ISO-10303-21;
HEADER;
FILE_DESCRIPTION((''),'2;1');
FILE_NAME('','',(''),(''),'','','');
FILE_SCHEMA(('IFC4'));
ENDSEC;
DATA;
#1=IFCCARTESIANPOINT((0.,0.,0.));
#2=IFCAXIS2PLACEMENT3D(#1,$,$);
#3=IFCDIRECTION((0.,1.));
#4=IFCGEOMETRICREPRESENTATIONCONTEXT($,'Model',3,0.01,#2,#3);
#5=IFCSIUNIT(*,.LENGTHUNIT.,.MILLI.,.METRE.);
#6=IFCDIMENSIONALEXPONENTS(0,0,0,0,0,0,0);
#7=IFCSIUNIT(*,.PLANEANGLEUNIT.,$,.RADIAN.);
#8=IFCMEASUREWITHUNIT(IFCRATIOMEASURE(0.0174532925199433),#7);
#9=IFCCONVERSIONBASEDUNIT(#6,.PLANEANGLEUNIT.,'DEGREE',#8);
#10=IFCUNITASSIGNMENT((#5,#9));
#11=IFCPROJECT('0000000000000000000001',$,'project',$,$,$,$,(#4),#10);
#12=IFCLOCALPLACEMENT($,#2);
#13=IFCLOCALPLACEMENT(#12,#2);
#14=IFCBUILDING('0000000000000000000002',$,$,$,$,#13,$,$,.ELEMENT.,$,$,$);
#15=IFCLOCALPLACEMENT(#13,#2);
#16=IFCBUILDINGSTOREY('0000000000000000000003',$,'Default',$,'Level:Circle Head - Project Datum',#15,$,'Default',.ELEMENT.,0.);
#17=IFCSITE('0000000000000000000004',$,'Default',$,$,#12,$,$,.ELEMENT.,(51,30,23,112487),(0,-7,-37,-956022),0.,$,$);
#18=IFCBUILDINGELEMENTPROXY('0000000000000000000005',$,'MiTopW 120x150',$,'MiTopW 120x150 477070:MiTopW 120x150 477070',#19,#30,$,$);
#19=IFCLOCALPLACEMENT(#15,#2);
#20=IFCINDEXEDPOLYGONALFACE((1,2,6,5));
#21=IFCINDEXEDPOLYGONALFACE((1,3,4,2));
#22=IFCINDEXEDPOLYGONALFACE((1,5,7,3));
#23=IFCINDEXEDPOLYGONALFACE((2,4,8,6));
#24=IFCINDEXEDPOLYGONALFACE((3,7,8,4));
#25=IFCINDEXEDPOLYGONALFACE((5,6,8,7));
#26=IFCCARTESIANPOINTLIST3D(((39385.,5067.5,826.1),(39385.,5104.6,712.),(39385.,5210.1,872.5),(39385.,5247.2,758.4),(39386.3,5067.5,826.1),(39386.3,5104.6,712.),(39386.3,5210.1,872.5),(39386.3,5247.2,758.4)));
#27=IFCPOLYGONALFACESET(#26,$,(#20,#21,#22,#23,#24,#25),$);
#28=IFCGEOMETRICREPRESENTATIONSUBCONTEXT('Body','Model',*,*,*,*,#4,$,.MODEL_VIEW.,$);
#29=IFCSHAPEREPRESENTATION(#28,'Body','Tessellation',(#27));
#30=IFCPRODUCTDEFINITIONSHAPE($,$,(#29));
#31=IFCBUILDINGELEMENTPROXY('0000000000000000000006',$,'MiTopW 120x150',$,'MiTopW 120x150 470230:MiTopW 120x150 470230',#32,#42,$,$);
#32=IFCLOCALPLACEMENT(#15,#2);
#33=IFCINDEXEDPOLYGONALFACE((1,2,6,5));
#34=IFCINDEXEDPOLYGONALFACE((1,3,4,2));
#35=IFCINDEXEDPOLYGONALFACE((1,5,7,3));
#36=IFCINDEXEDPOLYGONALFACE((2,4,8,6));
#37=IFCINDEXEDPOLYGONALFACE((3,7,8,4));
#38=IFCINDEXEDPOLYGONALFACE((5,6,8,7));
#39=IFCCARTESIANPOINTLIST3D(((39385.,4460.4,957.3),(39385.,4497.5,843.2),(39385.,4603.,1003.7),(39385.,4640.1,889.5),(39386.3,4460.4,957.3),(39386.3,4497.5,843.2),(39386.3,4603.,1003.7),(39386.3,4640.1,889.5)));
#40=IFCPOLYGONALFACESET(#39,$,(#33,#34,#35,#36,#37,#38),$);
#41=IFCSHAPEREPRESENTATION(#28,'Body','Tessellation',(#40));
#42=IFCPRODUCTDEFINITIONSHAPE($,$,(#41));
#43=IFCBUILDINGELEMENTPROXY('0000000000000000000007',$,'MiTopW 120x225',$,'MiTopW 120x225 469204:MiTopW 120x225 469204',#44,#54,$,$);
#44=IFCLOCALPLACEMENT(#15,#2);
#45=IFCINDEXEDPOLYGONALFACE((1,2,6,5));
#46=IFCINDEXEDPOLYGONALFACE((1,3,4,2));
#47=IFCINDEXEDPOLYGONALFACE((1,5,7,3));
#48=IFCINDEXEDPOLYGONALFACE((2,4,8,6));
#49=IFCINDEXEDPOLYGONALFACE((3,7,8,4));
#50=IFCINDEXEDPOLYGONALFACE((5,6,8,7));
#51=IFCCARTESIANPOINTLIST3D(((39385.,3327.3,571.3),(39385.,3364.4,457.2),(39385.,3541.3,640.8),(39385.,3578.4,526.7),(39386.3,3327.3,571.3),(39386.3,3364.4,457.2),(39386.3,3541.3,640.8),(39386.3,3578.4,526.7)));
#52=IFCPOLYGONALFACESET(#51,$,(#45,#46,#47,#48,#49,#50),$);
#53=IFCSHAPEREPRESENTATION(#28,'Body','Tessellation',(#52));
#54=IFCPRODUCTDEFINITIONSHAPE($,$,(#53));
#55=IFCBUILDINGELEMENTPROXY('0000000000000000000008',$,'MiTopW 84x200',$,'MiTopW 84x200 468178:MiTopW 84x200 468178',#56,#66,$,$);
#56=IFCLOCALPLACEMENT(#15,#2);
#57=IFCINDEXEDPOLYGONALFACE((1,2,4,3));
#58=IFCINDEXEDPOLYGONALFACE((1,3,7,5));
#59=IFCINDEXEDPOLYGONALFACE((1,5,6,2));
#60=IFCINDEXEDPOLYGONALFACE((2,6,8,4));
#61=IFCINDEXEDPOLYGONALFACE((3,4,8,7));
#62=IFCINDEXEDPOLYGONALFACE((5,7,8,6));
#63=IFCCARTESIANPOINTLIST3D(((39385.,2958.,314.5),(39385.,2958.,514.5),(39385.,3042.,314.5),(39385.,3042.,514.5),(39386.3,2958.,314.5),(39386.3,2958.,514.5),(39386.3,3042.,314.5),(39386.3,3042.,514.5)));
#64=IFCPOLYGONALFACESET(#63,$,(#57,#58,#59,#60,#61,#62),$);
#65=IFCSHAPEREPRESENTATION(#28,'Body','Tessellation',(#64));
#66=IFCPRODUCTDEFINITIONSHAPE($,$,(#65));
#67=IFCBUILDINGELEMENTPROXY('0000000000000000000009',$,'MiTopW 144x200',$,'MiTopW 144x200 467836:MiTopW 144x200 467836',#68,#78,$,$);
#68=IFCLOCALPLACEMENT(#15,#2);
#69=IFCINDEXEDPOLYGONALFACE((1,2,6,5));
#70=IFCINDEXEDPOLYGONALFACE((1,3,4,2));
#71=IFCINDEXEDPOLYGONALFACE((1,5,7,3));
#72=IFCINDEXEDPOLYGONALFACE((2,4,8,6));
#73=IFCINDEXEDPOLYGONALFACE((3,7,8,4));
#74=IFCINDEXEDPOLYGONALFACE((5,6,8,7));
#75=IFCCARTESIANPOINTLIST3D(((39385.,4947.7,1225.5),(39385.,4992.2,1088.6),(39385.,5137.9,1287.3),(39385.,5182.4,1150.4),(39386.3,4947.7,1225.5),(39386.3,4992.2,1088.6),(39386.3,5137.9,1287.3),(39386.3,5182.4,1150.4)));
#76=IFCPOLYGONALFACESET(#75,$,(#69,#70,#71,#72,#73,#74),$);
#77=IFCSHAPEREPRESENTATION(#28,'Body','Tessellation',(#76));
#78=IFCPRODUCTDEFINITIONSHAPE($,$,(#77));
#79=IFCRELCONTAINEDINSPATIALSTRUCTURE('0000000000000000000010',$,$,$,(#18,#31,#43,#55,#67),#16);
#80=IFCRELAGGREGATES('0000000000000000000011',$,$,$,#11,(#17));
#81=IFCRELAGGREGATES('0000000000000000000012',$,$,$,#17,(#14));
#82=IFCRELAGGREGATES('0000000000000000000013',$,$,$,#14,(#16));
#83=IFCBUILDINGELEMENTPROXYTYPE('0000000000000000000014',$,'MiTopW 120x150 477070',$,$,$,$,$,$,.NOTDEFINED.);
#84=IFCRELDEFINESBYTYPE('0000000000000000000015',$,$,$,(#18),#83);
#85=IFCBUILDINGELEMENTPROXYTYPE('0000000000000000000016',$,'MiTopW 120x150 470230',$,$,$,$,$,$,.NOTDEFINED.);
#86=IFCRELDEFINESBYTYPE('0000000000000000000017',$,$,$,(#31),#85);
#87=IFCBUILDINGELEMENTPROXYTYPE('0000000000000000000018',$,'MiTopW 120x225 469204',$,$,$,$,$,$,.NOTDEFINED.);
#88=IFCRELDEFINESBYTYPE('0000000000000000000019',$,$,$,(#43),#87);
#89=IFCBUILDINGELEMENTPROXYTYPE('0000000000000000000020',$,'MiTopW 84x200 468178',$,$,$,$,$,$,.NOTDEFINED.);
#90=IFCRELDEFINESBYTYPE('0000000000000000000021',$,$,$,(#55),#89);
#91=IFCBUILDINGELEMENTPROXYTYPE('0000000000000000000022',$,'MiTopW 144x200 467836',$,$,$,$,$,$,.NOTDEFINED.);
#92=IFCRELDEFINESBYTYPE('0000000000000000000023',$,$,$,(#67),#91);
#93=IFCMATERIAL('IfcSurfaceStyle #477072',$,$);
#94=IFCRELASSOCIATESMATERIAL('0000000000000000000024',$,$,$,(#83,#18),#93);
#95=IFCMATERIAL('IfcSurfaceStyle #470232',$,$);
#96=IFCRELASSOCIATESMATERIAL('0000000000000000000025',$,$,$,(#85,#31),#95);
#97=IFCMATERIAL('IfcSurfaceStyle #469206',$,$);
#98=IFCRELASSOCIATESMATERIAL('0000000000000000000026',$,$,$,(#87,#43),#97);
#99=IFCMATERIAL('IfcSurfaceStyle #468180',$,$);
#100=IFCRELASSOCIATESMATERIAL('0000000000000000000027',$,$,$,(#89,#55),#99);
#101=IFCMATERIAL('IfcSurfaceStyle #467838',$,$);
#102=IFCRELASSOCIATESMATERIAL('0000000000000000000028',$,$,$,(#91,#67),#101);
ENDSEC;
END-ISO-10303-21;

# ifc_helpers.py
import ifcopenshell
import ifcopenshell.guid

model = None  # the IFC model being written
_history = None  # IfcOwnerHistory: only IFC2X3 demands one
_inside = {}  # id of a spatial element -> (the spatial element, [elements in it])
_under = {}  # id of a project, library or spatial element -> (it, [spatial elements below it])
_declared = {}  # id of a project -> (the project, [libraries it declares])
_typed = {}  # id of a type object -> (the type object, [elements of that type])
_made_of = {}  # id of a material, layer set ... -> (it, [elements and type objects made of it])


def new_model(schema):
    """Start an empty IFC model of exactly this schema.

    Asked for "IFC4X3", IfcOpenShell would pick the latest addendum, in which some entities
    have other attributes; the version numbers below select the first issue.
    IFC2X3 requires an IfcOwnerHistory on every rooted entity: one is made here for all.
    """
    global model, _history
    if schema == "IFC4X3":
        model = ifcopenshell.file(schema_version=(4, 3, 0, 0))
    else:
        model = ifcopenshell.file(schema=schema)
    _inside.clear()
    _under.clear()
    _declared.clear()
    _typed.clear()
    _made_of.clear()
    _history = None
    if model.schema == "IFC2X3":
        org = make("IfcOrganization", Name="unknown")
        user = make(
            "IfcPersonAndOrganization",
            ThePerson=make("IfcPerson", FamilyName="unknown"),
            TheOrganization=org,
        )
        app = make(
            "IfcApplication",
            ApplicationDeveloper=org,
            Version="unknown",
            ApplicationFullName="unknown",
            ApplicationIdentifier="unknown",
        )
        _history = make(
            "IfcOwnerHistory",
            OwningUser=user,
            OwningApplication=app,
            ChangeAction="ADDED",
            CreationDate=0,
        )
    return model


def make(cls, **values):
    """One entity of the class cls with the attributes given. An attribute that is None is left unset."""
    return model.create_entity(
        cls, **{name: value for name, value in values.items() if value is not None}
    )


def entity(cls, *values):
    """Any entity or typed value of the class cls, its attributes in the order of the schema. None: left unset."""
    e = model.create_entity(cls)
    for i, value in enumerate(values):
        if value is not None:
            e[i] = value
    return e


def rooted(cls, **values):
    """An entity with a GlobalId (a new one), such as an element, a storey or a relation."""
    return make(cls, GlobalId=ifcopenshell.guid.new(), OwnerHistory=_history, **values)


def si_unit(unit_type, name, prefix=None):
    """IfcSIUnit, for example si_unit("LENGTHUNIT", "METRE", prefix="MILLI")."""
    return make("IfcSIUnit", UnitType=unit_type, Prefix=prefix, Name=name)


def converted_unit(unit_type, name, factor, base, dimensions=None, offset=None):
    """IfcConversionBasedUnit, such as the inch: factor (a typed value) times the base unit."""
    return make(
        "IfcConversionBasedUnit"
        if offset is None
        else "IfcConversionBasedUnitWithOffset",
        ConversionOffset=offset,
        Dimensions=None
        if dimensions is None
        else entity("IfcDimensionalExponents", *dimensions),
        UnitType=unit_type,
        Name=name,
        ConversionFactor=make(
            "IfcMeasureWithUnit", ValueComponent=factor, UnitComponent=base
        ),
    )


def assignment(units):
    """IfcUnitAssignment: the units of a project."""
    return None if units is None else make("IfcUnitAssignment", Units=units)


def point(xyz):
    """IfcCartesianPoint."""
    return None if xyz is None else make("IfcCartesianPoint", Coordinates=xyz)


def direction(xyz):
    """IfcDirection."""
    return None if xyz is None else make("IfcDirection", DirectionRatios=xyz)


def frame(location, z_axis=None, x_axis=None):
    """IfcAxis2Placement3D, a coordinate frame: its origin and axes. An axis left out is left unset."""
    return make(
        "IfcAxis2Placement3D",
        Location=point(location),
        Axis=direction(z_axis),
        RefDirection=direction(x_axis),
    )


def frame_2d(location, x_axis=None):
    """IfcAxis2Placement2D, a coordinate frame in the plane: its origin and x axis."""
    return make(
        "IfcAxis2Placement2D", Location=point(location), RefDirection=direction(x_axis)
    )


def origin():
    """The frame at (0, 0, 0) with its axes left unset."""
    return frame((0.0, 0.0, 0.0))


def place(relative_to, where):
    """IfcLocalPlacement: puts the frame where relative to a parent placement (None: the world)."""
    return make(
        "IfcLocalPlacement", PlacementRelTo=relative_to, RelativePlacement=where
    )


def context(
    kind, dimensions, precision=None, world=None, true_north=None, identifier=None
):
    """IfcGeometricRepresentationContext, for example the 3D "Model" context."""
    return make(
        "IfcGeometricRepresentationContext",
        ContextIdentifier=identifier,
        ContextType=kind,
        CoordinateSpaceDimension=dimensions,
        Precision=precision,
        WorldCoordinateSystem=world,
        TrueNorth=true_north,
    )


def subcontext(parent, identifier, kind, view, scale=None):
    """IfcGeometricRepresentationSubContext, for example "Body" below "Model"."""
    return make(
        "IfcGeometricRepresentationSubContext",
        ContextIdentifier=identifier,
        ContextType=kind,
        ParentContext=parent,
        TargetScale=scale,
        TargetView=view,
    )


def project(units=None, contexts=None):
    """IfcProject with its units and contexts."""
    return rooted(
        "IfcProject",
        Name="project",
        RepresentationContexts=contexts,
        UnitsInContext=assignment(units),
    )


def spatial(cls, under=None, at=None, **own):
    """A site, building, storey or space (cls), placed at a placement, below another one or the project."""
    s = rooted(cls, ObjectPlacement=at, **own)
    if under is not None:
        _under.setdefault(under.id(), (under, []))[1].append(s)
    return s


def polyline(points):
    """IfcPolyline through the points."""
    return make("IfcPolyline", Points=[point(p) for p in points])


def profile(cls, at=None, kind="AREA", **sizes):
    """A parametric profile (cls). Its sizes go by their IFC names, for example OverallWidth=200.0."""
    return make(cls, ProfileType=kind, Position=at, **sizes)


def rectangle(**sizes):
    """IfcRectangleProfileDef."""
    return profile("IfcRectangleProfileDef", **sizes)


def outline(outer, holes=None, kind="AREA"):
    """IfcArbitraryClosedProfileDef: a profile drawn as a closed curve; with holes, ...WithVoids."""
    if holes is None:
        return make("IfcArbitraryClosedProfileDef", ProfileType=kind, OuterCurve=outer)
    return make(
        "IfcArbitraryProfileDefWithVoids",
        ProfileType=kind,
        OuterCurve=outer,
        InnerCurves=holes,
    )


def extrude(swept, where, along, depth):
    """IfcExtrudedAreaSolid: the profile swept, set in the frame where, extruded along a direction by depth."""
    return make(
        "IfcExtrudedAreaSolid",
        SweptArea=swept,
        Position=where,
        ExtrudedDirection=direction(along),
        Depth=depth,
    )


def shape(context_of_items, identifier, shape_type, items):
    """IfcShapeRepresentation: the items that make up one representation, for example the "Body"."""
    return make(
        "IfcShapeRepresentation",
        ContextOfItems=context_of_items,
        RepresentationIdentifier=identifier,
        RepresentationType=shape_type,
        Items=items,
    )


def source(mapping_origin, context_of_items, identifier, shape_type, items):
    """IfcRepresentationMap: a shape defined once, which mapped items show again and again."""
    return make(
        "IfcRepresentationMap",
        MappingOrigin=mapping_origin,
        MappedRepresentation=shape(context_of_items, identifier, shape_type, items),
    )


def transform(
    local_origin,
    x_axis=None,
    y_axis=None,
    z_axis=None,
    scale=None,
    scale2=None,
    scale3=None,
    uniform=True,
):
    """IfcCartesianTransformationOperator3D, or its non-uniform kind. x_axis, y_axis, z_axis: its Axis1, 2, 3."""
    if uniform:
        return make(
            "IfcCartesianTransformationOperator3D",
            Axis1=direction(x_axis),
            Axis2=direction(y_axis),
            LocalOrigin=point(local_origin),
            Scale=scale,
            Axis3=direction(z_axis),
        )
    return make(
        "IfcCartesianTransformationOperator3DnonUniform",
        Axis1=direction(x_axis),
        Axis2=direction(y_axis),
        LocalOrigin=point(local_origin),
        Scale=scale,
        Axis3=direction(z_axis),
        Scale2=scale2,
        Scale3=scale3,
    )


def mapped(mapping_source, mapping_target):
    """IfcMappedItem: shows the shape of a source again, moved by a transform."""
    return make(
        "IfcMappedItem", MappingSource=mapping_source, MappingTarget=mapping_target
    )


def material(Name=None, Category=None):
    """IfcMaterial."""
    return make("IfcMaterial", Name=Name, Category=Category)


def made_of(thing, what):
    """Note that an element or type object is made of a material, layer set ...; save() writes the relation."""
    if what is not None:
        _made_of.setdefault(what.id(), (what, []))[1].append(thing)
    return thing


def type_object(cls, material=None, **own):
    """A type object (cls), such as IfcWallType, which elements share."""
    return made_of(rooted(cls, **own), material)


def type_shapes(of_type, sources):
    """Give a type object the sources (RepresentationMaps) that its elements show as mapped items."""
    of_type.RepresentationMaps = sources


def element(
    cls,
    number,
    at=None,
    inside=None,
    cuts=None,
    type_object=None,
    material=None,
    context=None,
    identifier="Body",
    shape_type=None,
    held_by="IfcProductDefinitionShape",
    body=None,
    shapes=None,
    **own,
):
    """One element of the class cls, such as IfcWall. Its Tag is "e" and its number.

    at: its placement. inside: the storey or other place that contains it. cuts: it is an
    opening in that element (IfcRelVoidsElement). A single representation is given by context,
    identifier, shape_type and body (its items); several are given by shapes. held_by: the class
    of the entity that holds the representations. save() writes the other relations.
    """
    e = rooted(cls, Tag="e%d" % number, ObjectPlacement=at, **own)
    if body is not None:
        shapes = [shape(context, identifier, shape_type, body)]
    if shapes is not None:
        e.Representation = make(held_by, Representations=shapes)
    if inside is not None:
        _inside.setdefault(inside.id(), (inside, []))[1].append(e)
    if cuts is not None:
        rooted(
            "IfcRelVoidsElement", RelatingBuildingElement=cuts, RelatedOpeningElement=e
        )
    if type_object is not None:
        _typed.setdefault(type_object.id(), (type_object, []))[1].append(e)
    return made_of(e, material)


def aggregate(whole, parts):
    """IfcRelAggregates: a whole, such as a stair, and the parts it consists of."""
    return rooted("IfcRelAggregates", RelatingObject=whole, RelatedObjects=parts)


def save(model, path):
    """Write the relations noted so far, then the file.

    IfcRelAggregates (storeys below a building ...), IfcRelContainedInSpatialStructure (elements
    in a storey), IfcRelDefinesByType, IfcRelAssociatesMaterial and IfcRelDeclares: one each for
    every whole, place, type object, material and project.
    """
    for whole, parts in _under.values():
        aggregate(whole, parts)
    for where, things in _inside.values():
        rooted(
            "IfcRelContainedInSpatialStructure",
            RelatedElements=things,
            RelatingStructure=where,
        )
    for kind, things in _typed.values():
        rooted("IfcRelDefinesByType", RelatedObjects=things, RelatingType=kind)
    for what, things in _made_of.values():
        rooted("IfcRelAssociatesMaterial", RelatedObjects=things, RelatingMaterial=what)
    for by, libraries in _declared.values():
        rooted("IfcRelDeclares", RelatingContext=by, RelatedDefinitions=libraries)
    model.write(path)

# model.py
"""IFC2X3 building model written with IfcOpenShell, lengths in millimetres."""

from ifc_helpers import new_model, entity, si_unit, converted_unit, direction, frame, frame_2d, origin, place, context, subcontext, project, spatial, polyline, rectangle, outline, extrude, source, transform, mapped, material, type_object, type_shapes, element, save


model = new_model("IFC2X3")

# Units and contexts
model_context = context("Model", 3, precision=0.01, world=origin(), true_north=direction((0.0, 1.0)))
body_context = subcontext(model_context, "Body", "Model", "MODEL_VIEW")
ifc_project = project(units=[si_unit("LENGTHUNIT", "METRE", prefix="MILLI"), converted_unit("PLANEANGLEUNIT", "DEGREE", entity("IfcRatioMeasure", 0.0174532925199433), si_unit("PLANEANGLEUNIT", "RADIAN"), dimensions=[0, 0, 0, 0, 0, 0, 0])], contexts=[model_context])

# Site, building, storey
site_placement = place(None, origin())
site = spatial("IfcSite", under=ifc_project, at=site_placement, Name="Default", CompositionType="ELEMENT", RefLatitude=(51, 30, 23, 112487), RefLongitude=(0, -7, -37, -956022), RefElevation=0.0)
building_placement = place(site_placement, origin())
building = spatial("IfcBuilding", under=site, at=building_placement, CompositionType="ELEMENT")
storey_placement = place(building_placement, origin())
storey = spatial("IfcBuildingStorey", under=building, at=storey_placement, Name="Default", ObjectType="Level:Circle Head - Project Datum", LongName="Default", CompositionType="ELEMENT", Elevation=0.0)

# Building element proxies
ifc_material_1 = material(Name="IfcSurfaceStyle #477072")
building_element_proxy_type_1 = type_object("IfcBuildingElementProxyType", Name="MiTopW 120x150 477070", PredefinedType="NOTDEFINED", material=ifc_material_1)
shared_shape_1 = source(origin(), body_context, "Body", "SweptSolid", [
    extrude(outline(polyline([(-75.0, -60.0), (75.0, -60.0), (75.0, 60.0), (-75.0, 60.0), (-75.0, -60.0)])), frame((75.0, 60.0, 0.0), z_axis=(0.0, 0.0, 1.0), x_axis=(-1.0, 0.0, 0.0)), (0.0, 0.0, 1.0), 1.3),
])
type_shapes(building_element_proxy_type_1, [shared_shape_1])
proxy_1_placement = place(building_placement, frame((39386.3, 5067.5, 826.1), z_axis=(-1.0, 0.0, 0.0), x_axis=(0.0, 0.951057, 0.309017)))
element("IfcBuildingElementProxy", 1, at=proxy_1_placement, inside=storey, type_object=building_element_proxy_type_1, material=ifc_material_1, Name="MiTopW 120x150", ObjectType="MiTopW 120x150 477070:MiTopW 120x150 477070", context=body_context, shape_type="MappedRepresentation", body=[
    mapped(shared_shape_1, transform((0.0, 0.0, 0.0), scale=1.0)),
])
ifc_material_2 = material(Name="IfcSurfaceStyle #470232")
building_element_proxy_type_2 = type_object("IfcBuildingElementProxyType", Name="MiTopW 120x150 470230", PredefinedType="NOTDEFINED", material=ifc_material_2)
shared_shape_2 = source(origin(), body_context, "Body", "SweptSolid", [
    extrude(outline(polyline([(-75.0, -60.0), (75.0, -60.0), (75.0, 60.0), (-75.0, 60.0), (-75.0, -60.0)])), frame((75.0, 60.0, 0.0), z_axis=(0.0, 0.0, 1.0), x_axis=(-1.0, 0.0, 0.0)), (0.0, 0.0, 1.0), 1.3),
])
type_shapes(building_element_proxy_type_2, [shared_shape_2])
proxy_2_placement = place(building_placement, frame((39386.3, 4460.4, 957.3), z_axis=(-1.0, 0.0, 0.0), x_axis=(0.0, 0.951057, 0.309017)))
element("IfcBuildingElementProxy", 2, at=proxy_2_placement, inside=storey, type_object=building_element_proxy_type_2, material=ifc_material_2, Name="MiTopW 120x150", ObjectType="MiTopW 120x150 470230:MiTopW 120x150 470230", context=body_context, shape_type="MappedRepresentation", body=[
    mapped(shared_shape_2, transform((0.0, 0.0, 0.0), scale=1.0)),
])
ifc_material_3 = material(Name="IfcSurfaceStyle #469206")
building_element_proxy_type_3 = type_object("IfcBuildingElementProxyType", Name="MiTopW 120x225 469204", PredefinedType="NOTDEFINED", material=ifc_material_3)
shared_shape_3 = source(origin(), body_context, "Body", "SweptSolid", [
    extrude(outline(polyline([(-112.5, -60.0), (112.5, -60.0), (112.5, 60.0), (-112.5, 60.0), (-112.5, -60.0)])), frame((112.5, 60.0, 0.0), z_axis=(0.0, 0.0, 1.0), x_axis=(-1.0, 0.0, 0.0)), (0.0, 0.0, 1.0), 1.3),
])
type_shapes(building_element_proxy_type_3, [shared_shape_3])
proxy_3_placement = place(building_placement, frame((39386.3, 3327.3, 571.3), z_axis=(-1.0, 0.0, 0.0), x_axis=(0.0, 0.951057, 0.309017)))
element("IfcBuildingElementProxy", 3, at=proxy_3_placement, inside=storey, type_object=building_element_proxy_type_3, material=ifc_material_3, Name="MiTopW 120x225", ObjectType="MiTopW 120x225 469204:MiTopW 120x225 469204", context=body_context, shape_type="MappedRepresentation", body=[
    mapped(shared_shape_3, transform((0.0, 0.0, 0.0), scale=1.0)),
])
ifc_material_4 = material(Name="IfcSurfaceStyle #468180")
building_element_proxy_type_4 = type_object("IfcBuildingElementProxyType", Name="MiTopW 84x200 468178", PredefinedType="NOTDEFINED", material=ifc_material_4)
shared_shape_4 = source(origin(), body_context, "Body", "SweptSolid", [
    extrude(rectangle(XDim=200.0, YDim=84.0, at=frame_2d((0.0, 0.0), x_axis=(1.0, 0.0))), frame((100.0, 42.0, 0.0), z_axis=(0.0, 0.0, 1.0), x_axis=(-1.0, 0.0, 0.0)), (0.0, 0.0, 1.0), 1.3),
])
type_shapes(building_element_proxy_type_4, [shared_shape_4])
proxy_4_placement = place(building_placement, frame((39386.3, 3042.0, 514.5), z_axis=(-1.0, 0.0, 0.0), x_axis=(0.0, 0.0, -1.0)))
element("IfcBuildingElementProxy", 4, at=proxy_4_placement, inside=storey, type_object=building_element_proxy_type_4, material=ifc_material_4, Name="MiTopW 84x200", ObjectType="MiTopW 84x200 468178:MiTopW 84x200 468178", context=body_context, shape_type="MappedRepresentation", body=[
    mapped(shared_shape_4, transform((0.0, 0.0, 0.0), scale=1.0)),
])
ifc_material_5 = material(Name="IfcSurfaceStyle #467838")
building_element_proxy_type_5 = type_object("IfcBuildingElementProxyType", Name="MiTopW 144x200 467836", PredefinedType="NOTDEFINED", material=ifc_material_5)
shared_shape_5 = source(origin(), body_context, "Body", "SweptSolid", [
    extrude(outline(polyline([(-100.0, -72.0), (100.0, -72.0), (100.0, 72.0), (-100.0, 72.0), (-100.0, -72.0)])), frame((100.0, 72.0, 0.0), z_axis=(0.0, 0.0, 1.0), x_axis=(-1.0, 0.0, 0.0)), (0.0, 0.0, 1.0), 1.3),
])
type_shapes(building_element_proxy_type_5, [shared_shape_5])
proxy_5_placement = place(building_placement, frame((39386.3, 4947.7, 1225.5), z_axis=(-1.0, 0.0, 0.0), x_axis=(0.0, 0.951057, 0.309017)))
element("IfcBuildingElementProxy", 5, at=proxy_5_placement, inside=storey, type_object=building_element_proxy_type_5, material=ifc_material_5, Name="MiTopW 144x200", ObjectType="MiTopW 144x200 467836:MiTopW 144x200 467836", context=body_context, shape_type="MappedRepresentation", body=[
    mapped(shared_shape_5, transform((0.0, 0.0, 0.0), scale=1.0)),
])

save(model, "model.ifc")
